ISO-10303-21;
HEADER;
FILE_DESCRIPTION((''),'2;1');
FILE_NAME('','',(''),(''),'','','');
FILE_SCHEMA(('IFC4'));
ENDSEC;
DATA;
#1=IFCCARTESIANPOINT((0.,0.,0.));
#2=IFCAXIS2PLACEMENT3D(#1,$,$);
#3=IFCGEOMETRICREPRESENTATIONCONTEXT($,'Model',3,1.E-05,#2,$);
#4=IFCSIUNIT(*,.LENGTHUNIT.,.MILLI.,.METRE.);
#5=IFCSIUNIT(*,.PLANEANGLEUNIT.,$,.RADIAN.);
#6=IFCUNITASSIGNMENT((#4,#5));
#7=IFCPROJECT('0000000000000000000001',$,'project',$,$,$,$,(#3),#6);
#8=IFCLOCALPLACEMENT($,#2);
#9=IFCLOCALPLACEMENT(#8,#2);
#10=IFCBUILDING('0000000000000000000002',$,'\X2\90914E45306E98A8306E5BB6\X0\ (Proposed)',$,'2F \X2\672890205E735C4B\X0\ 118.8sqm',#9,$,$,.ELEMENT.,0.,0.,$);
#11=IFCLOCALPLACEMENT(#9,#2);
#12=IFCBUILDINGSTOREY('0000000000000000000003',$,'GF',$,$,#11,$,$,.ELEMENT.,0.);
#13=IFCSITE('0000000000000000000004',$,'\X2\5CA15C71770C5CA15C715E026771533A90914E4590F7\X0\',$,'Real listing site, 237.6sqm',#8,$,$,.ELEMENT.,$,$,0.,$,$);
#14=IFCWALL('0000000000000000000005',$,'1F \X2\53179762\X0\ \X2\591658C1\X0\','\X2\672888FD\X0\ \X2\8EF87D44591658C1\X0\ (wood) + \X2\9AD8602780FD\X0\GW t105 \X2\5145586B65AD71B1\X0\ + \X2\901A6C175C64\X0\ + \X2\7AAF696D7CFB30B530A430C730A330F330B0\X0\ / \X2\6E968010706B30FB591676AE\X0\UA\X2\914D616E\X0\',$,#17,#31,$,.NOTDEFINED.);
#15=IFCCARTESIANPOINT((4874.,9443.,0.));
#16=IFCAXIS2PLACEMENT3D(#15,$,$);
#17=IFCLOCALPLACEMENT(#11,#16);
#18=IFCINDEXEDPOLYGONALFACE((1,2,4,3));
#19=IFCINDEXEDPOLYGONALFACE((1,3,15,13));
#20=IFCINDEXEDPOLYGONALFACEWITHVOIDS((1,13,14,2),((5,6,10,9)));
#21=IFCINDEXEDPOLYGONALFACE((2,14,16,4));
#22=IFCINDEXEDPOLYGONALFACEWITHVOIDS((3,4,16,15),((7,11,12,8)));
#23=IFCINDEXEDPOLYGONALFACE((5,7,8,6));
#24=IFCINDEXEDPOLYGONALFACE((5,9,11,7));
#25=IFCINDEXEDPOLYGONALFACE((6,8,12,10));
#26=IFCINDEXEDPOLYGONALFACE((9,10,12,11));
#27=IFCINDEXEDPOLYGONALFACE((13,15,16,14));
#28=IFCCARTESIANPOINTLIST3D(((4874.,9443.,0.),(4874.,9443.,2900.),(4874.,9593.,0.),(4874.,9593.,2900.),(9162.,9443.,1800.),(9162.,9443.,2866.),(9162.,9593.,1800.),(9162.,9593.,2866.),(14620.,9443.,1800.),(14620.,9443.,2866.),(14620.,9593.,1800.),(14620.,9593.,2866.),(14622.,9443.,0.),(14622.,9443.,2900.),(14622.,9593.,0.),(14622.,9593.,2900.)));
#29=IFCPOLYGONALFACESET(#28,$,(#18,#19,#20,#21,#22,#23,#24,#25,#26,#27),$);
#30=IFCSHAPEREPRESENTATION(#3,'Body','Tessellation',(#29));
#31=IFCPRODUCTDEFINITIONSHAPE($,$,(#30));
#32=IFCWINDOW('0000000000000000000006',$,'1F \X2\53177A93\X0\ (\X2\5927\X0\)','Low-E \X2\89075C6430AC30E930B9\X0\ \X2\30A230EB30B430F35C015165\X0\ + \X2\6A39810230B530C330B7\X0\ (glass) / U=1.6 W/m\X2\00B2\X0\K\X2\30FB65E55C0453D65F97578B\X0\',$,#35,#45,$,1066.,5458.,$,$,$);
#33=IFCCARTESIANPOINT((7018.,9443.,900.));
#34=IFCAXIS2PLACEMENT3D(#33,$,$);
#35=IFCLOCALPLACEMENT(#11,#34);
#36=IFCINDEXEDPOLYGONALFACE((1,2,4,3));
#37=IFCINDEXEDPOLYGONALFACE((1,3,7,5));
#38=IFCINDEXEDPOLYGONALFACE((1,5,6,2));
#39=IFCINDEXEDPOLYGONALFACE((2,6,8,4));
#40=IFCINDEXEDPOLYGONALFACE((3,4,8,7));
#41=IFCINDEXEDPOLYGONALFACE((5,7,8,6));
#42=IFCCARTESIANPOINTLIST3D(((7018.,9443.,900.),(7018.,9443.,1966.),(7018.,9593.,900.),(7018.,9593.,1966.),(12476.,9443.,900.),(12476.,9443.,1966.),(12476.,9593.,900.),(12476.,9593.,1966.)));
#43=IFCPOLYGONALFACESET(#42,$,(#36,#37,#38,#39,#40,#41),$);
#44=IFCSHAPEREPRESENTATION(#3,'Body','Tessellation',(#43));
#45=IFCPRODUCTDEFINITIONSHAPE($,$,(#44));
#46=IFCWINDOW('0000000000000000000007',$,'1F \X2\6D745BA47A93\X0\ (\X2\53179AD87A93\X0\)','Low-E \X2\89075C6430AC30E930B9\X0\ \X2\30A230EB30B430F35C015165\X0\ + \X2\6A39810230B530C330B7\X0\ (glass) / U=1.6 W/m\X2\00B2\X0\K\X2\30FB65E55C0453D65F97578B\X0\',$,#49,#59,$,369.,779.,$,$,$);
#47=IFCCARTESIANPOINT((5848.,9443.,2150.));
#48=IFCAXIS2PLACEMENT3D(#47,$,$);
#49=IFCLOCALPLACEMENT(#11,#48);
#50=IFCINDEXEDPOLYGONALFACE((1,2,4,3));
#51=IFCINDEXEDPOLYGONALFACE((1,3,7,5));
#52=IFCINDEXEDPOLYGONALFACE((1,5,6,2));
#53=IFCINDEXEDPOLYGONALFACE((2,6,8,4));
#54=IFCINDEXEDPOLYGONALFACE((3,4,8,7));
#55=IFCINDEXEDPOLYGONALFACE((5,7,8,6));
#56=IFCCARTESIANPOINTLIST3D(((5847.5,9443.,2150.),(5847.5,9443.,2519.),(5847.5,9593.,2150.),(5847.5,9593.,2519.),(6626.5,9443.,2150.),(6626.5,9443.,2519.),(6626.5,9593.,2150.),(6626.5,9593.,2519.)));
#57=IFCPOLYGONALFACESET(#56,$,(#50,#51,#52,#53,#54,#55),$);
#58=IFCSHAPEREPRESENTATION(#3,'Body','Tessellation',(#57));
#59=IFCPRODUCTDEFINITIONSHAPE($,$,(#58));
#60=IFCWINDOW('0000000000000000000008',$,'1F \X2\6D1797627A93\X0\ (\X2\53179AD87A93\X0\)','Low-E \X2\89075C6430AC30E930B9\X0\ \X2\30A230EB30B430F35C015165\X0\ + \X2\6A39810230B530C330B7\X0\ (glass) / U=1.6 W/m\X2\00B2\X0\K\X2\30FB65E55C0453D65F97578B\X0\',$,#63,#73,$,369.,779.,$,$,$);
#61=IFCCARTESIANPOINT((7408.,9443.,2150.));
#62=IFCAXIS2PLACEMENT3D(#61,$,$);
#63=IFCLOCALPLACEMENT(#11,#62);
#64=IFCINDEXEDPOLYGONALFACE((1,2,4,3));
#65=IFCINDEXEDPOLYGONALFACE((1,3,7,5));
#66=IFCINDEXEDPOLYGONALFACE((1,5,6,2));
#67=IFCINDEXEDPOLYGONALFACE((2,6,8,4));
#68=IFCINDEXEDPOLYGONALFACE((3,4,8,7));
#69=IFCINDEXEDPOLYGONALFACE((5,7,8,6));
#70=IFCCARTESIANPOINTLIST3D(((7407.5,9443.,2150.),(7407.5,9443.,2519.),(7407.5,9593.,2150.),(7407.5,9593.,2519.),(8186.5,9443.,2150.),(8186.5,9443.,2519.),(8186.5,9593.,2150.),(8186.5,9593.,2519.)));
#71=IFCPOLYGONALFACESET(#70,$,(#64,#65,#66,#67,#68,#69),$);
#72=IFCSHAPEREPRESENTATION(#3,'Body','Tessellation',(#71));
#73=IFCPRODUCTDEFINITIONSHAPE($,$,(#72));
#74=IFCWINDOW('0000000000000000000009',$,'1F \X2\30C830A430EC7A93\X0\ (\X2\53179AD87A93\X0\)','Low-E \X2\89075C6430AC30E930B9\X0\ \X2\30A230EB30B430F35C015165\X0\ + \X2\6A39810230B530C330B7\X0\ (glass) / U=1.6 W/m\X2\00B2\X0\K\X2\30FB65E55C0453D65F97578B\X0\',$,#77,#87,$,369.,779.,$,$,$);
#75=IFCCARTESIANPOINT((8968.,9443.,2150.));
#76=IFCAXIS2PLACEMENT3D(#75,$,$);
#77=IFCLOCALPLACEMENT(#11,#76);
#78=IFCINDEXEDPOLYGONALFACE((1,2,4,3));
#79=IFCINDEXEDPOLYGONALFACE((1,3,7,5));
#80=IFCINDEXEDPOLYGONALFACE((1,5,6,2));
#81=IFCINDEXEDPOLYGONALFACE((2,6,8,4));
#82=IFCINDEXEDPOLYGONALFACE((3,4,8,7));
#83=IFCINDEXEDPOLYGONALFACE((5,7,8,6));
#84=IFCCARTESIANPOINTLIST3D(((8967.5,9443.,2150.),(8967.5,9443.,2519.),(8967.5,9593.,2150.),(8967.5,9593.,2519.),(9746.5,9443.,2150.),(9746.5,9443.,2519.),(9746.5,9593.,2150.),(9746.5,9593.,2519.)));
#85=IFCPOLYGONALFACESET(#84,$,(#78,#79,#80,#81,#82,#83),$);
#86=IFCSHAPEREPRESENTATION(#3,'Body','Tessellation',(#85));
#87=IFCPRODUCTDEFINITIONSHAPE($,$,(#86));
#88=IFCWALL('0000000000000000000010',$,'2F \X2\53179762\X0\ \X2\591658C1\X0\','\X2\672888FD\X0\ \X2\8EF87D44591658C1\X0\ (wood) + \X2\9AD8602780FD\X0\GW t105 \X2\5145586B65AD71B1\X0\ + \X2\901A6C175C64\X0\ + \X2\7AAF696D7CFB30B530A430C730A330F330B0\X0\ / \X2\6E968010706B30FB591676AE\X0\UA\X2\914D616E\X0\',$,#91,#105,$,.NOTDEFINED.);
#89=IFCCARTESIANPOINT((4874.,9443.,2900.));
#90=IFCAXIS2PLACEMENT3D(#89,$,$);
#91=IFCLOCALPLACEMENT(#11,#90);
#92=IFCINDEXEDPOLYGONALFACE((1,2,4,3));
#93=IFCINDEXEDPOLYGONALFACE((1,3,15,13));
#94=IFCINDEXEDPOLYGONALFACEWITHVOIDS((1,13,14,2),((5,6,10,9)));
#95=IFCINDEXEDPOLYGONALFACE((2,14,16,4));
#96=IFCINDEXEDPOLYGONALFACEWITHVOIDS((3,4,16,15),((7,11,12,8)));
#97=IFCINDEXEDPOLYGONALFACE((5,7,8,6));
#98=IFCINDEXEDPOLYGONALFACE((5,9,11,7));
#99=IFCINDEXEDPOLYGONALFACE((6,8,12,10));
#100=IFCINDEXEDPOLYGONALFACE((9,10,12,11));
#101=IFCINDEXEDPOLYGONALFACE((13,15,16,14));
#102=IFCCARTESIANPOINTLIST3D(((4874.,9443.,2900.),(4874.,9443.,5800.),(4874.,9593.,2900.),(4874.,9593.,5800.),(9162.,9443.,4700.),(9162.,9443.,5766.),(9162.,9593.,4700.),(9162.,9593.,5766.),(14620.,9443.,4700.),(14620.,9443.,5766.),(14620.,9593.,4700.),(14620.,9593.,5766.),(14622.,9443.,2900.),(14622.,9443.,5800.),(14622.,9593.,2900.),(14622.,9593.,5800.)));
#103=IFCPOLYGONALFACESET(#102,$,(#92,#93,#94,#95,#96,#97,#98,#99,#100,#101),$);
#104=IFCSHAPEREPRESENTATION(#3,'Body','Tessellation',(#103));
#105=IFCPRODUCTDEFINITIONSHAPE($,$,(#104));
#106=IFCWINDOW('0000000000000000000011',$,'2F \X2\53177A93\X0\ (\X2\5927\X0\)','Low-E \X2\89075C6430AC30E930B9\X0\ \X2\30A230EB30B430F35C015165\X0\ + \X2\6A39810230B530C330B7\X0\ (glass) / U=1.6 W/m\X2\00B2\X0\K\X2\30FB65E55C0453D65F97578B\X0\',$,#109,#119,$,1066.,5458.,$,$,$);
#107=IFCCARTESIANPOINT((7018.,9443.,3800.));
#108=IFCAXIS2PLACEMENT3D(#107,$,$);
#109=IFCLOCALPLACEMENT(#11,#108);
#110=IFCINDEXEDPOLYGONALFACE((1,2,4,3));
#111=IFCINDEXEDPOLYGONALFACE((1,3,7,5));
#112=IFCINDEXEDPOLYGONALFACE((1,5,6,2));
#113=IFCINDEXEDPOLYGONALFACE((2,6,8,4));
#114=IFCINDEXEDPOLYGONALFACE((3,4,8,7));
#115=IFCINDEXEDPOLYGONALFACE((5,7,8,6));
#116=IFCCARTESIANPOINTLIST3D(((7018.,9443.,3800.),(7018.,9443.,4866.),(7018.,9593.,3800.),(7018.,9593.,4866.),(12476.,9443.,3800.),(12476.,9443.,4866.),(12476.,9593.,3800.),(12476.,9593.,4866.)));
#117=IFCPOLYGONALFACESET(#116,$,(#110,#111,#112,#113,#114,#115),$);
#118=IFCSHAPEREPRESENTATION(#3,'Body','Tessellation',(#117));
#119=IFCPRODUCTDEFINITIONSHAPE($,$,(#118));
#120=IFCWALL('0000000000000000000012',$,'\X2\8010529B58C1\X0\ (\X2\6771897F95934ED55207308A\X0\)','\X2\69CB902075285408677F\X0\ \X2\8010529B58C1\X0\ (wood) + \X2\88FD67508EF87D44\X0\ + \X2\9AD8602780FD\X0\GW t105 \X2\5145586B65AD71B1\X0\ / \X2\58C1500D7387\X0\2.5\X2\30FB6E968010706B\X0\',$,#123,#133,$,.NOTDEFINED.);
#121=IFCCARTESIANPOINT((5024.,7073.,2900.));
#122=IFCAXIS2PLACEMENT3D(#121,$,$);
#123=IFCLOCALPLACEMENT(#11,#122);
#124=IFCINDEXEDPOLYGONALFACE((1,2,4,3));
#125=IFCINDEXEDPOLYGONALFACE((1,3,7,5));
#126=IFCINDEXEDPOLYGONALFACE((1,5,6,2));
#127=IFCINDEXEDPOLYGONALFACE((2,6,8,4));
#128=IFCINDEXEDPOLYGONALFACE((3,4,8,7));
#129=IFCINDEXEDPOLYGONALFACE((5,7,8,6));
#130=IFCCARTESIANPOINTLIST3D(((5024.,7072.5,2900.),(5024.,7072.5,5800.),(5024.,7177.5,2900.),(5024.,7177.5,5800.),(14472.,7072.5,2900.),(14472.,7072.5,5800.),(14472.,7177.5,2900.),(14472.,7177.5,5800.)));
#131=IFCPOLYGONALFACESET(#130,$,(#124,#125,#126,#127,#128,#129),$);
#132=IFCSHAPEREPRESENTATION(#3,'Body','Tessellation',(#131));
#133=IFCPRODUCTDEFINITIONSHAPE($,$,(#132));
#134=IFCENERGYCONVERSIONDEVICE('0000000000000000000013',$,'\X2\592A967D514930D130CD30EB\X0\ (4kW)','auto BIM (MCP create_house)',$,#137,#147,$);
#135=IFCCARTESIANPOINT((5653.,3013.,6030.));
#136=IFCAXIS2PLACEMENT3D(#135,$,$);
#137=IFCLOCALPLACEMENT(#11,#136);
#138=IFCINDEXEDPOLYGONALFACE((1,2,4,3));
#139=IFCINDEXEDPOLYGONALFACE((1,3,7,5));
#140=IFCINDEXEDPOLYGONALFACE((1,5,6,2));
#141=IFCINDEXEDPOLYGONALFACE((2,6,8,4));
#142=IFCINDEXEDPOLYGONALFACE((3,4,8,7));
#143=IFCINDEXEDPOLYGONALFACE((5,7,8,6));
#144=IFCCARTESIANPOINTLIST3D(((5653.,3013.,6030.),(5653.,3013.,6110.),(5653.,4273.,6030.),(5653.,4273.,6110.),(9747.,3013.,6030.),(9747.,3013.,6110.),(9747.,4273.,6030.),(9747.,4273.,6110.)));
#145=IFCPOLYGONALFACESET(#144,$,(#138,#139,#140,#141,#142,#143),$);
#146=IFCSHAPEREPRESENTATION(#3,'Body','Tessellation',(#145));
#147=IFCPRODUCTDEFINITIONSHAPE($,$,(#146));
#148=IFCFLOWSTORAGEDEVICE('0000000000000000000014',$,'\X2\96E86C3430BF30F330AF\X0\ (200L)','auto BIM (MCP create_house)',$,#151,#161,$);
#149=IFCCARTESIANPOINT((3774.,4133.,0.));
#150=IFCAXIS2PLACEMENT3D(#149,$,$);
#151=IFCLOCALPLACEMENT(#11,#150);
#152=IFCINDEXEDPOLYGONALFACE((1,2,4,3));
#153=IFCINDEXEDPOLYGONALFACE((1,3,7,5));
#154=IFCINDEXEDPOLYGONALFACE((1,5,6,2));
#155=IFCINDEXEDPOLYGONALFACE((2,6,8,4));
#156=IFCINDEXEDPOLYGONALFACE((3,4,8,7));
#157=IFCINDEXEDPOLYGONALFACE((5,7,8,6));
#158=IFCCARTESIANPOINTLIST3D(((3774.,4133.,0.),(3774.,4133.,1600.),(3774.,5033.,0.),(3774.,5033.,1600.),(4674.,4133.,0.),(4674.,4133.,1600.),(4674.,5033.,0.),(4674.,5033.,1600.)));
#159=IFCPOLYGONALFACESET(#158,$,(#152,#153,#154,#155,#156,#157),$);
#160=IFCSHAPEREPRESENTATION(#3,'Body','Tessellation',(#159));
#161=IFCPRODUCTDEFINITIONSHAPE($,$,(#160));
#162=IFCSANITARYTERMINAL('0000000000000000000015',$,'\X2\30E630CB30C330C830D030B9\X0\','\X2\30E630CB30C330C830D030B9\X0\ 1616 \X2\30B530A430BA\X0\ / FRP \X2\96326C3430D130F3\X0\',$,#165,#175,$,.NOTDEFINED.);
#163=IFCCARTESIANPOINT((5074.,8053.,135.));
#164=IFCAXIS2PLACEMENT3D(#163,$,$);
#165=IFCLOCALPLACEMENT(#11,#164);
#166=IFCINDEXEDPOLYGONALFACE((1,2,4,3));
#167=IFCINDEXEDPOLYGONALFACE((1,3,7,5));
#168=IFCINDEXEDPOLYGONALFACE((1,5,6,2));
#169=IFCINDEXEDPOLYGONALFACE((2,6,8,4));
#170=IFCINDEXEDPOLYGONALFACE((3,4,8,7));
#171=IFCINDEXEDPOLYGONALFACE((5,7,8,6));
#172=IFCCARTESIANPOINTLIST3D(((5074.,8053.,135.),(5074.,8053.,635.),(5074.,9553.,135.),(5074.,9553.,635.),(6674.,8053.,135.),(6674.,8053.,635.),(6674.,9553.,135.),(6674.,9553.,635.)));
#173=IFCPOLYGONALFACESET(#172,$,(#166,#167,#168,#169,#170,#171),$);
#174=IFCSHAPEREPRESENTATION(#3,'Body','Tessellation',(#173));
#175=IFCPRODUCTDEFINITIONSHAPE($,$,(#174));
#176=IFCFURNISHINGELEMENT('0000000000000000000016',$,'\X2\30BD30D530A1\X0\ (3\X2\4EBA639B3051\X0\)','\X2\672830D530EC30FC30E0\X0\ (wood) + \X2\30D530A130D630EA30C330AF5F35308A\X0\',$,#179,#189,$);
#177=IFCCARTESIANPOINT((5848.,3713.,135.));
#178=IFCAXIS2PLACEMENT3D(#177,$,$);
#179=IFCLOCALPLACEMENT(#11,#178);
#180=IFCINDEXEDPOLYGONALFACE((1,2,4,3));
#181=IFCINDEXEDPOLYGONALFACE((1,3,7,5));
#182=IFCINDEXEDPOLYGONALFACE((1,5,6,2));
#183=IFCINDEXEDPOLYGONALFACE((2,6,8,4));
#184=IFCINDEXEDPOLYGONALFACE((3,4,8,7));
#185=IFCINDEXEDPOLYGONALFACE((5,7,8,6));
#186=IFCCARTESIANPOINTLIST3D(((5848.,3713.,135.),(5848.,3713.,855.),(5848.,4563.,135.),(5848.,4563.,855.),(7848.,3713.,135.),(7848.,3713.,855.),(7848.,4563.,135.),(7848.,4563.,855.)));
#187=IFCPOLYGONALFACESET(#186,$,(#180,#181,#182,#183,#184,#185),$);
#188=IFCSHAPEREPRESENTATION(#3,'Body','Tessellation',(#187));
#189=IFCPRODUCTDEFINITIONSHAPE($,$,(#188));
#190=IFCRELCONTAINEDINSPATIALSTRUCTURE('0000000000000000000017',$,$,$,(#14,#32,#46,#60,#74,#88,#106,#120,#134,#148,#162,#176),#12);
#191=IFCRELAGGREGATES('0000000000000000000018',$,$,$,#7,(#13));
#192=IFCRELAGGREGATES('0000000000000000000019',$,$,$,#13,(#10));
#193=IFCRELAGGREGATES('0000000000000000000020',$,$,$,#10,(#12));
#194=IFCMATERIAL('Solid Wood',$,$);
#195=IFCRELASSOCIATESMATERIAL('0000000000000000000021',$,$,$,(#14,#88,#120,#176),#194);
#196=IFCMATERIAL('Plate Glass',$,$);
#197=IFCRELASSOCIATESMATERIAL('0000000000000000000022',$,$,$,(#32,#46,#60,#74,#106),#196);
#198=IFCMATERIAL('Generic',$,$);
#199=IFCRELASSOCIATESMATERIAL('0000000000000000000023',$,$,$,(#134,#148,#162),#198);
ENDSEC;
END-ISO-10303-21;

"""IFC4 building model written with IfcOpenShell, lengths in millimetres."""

from ifc_helpers import new_model, si_unit, frame, frame_2d, origin, place, context, project, spatial, rectangle, extrude, material, element, fill, save


model = new_model("IFC4")

# Units and contexts
model_context = context("Model", 3, precision=1e-05, world=origin())
ifc_project = project(units=[si_unit("LENGTHUNIT", "METRE", prefix="MILLI"), si_unit("PLANEANGLEUNIT", "RADIAN")], contexts=[model_context])

# Site, building, storey
site_placement = place(None, origin())
site = spatial("IfcSite", under=ifc_project, at=site_placement, Name="岡山県岡山市東区邑久郷", ObjectType="Real listing site, 237.6sqm", CompositionType="ELEMENT", RefElevation=0.0)
building_placement = place(site_placement, origin())
building = spatial("IfcBuilding", under=site, at=building_placement, Name="邑久の風の家 (Proposed)", ObjectType="2F 木造平屋 118.8sqm", CompositionType="ELEMENT", ElevationOfRefHeight=0.0, ElevationOfTerrain=0.0)
storey_placement = place(building_placement, origin())
storey = spatial("IfcBuildingStorey", under=building, at=storey_placement, Name="GF", CompositionType="ELEMENT", Elevation=0.0)

# Wall, openings, windows
ifc_material_1 = material(Name="Solid Wood")
wall_1_placement = place(storey_placement, frame((4874.0, 9443.0, 0.0)))
wall_1 = element("IfcWall", 1, at=wall_1_placement, inside=storey, material=ifc_material_1, Name="1F 北面 外壁", Description="木製 軸組外壁 (wood) + 高性能GW t105 充填断熱 + 通気層 + 窯業系サイディング / 準耐火・外皮UA配慮", PredefinedType="NOTDEFINED", context=model_context, shape_type="SweptSolid", body=[
    extrude(rectangle(XDim=9748.0, YDim=150.0, at=frame_2d((4874.0, 75.0))), frame((4874.0, 9443.0, 0.0)), (0.0, 0.0, 1.0), 2900.0),
])
opening_1_placement = place(storey_placement, frame((7018.0, 9443.0, 900.0)))
opening_1 = element("IfcOpeningElement", 2, at=opening_1_placement, cuts=wall_1, PredefinedType="NOTDEFINED", context=model_context, shape_type="SweptSolid", body=[
    extrude(rectangle(XDim=5458.0, YDim=150.0, at=frame_2d((2729.0, 75.0))), frame((7018.0, 9443.0, 900.0)), (0.0, 0.0, 1.0), 1066.0),
])
opening_2_placement = place(storey_placement, frame((5848.0, 9443.0, 2150.0)))
opening_2 = element("IfcOpeningElement", 3, at=opening_2_placement, cuts=wall_1, PredefinedType="NOTDEFINED", context=model_context, shape_type="SweptSolid", body=[
    extrude(rectangle(XDim=779.0, YDim=150.0, at=frame_2d((389.0, 75.0))), frame((5848.0, 9443.0, 2150.0)), (0.0, 0.0, 1.0), 369.0),
])
opening_3_placement = place(storey_placement, frame((7408.0, 9443.0, 2150.0)))
opening_3 = element("IfcOpeningElement", 4, at=opening_3_placement, cuts=wall_1, PredefinedType="NOTDEFINED", context=model_context, shape_type="SweptSolid", body=[
    extrude(rectangle(XDim=779.0, YDim=150.0, at=frame_2d((389.0, 75.0))), frame((7408.0, 9443.0, 2150.0)), (0.0, 0.0, 1.0), 369.0),
])
opening_4_placement = place(storey_placement, frame((8968.0, 9443.0, 2150.0)))
opening_4 = element("IfcOpeningElement", 5, at=opening_4_placement, cuts=wall_1, PredefinedType="NOTDEFINED", context=model_context, shape_type="SweptSolid", body=[
    extrude(rectangle(XDim=779.0, YDim=150.0, at=frame_2d((389.0, 75.0))), frame((8968.0, 9443.0, 2150.0)), (0.0, 0.0, 1.0), 369.0),
])
ifc_material_2 = material(Name="Plate Glass")
window_1_placement = place(storey_placement, frame((7018.0, 9443.0, 900.0)))
window_1 = element("IfcWindow", 6, at=window_1_placement, inside=storey, material=ifc_material_2, Name="1F 北窓 (大)", Description="Low-E 複層ガラス アルゴン封入 + 樹脂サッシ (glass) / U=1.6 W/m²K・日射取得型", OverallHeight=1066.0, OverallWidth=5458.0, context=model_context, shape_type="SweptSolid", body=[
    extrude(rectangle(XDim=5458.0, YDim=150.0, at=frame_2d((2729.0, 75.0))), frame((7018.0, 9443.0, 900.0)), (0.0, 0.0, 1.0), 1066.0),
])
fill(opening_1, window_1)
window_2_placement = place(storey_placement, frame((5848.0, 9443.0, 2150.0)))
window_2 = element("IfcWindow", 7, at=window_2_placement, inside=storey, material=ifc_material_2, Name="1F 浴室窓 (北高窓)", Description="Low-E 複層ガラス アルゴン封入 + 樹脂サッシ (glass) / U=1.6 W/m²K・日射取得型", OverallHeight=369.0, OverallWidth=779.0, context=model_context, shape_type="SweptSolid", body=[
    extrude(rectangle(XDim=779.0, YDim=150.0, at=frame_2d((389.0, 75.0))), frame((5848.0, 9443.0, 2150.0)), (0.0, 0.0, 1.0), 369.0),
])
fill(opening_2, window_2)
window_3_placement = place(storey_placement, frame((7408.0, 9443.0, 2150.0)))
window_3 = element("IfcWindow", 8, at=window_3_placement, inside=storey, material=ifc_material_2, Name="1F 洗面窓 (北高窓)", Description="Low-E 複層ガラス アルゴン封入 + 樹脂サッシ (glass) / U=1.6 W/m²K・日射取得型", OverallHeight=369.0, OverallWidth=779.0, context=model_context, shape_type="SweptSolid", body=[
    extrude(rectangle(XDim=779.0, YDim=150.0, at=frame_2d((389.0, 75.0))), frame((7408.0, 9443.0, 2150.0)), (0.0, 0.0, 1.0), 369.0),
])
fill(opening_3, window_3)
window_4_placement = place(storey_placement, frame((8968.0, 9443.0, 2150.0)))
window_4 = element("IfcWindow", 9, at=window_4_placement, inside=storey, material=ifc_material_2, Name="1F トイレ窓 (北高窓)", Description="Low-E 複層ガラス アルゴン封入 + 樹脂サッシ (glass) / U=1.6 W/m²K・日射取得型", OverallHeight=369.0, OverallWidth=779.0, context=model_context, shape_type="SweptSolid", body=[
    extrude(rectangle(XDim=779.0, YDim=150.0, at=frame_2d((389.0, 75.0))), frame((8968.0, 9443.0, 2150.0)), (0.0, 0.0, 1.0), 369.0),
])
fill(opening_4, window_4)

# Wall, opening, window
wall_2_placement = place(storey_placement, frame((4874.0, 9443.0, 2900.0)))
wall_2 = element("IfcWall", 10, at=wall_2_placement, inside=storey, material=ifc_material_1, Name="2F 北面 外壁", Description="木製 軸組外壁 (wood) + 高性能GW t105 充填断熱 + 通気層 + 窯業系サイディング / 準耐火・外皮UA配慮", PredefinedType="NOTDEFINED", context=model_context, shape_type="SweptSolid", body=[
    extrude(rectangle(XDim=9748.0, YDim=150.0, at=frame_2d((4874.0, 75.0))), frame((4874.0, 9443.0, 2900.0)), (0.0, 0.0, 1.0), 2900.0),
])
opening_5_placement = place(storey_placement, frame((7018.0, 9443.0, 3800.0)))
opening_5 = element("IfcOpeningElement", 11, at=opening_5_placement, cuts=wall_2, PredefinedType="NOTDEFINED", context=model_context, shape_type="SweptSolid", body=[
    extrude(rectangle(XDim=5458.0, YDim=150.0, at=frame_2d((2729.0, 75.0))), frame((7018.0, 9443.0, 3800.0)), (0.0, 0.0, 1.0), 1066.0),
])
window_5_placement = place(storey_placement, frame((7018.0, 9443.0, 3800.0)))
window_5 = element("IfcWindow", 12, at=window_5_placement, inside=storey, material=ifc_material_2, Name="2F 北窓 (大)", Description="Low-E 複層ガラス アルゴン封入 + 樹脂サッシ (glass) / U=1.6 W/m²K・日射取得型", OverallHeight=1066.0, OverallWidth=5458.0, context=model_context, shape_type="SweptSolid", body=[
    extrude(rectangle(XDim=5458.0, YDim=150.0, at=frame_2d((2729.0, 75.0))), frame((7018.0, 9443.0, 3800.0)), (0.0, 0.0, 1.0), 1066.0),
])
fill(opening_5, window_5)

# Wall
wall_3_placement = place(storey_placement, frame((5024.0, 7073.0, 2900.0)))
element("IfcWall", 13, at=wall_3_placement, inside=storey, material=ifc_material_1, Name="耐力壁 (東西間仕切り)", Description="構造用合板 耐力壁 (wood) + 製材軸組 + 高性能GW t105 充填断熱 / 壁倍率2.5・準耐火", PredefinedType="NOTDEFINED", context=model_context, shape_type="SweptSolid", body=[
    extrude(rectangle(XDim=9448.0, YDim=105.0, at=frame_2d((4724.0, 52.0))), frame((5024.0, 7073.0, 2900.0)), (0.0, 0.0, 1.0), 2900.0),
])

# Energy conversion device
ifc_material_3 = material(Name="Generic")
energy_conversion_device_placement = place(storey_placement, frame((5653.0, 3013.0, 6030.0)))
element("IfcEnergyConversionDevice", 14, at=energy_conversion_device_placement, inside=storey, material=ifc_material_3, Name="太陽光パネル (4kW)", Description="auto BIM (MCP create_house)", context=model_context, shape_type="SweptSolid", body=[
    extrude(rectangle(XDim=4094.0, YDim=1260.0, at=frame_2d((2047.0, 630.0))), frame((5653.0, 3013.0, 6030.0)), (0.0, 0.0, 1.0), 80.0),
])

# Flow storage device
flow_storage_device_placement = place(storey_placement, frame((3774.0, 4133.0, 0.0)))
element("IfcFlowStorageDevice", 15, at=flow_storage_device_placement, inside=storey, material=ifc_material_3, Name="雨水タンク (200L)", Description="auto BIM (MCP create_house)", context=model_context, shape_type="SweptSolid", body=[
    extrude(rectangle(XDim=900.0, YDim=900.0, at=frame_2d((450.0, 450.0))), frame((3774.0, 4133.0, 0.0)), (0.0, 0.0, 1.0), 1600.0),
])

# Sanitary terminal
sanitary_terminal_placement = place(storey_placement, frame((5074.0, 8053.0, 135.0)))
element("IfcSanitaryTerminal", 16, at=sanitary_terminal_placement, inside=storey, material=ifc_material_3, Name="ユニットバス", Description="ユニットバス 1616 サイズ / FRP 防水パン", PredefinedType="NOTDEFINED", context=model_context, shape_type="SweptSolid", body=[
    extrude(rectangle(XDim=1600.0, YDim=1500.0, at=frame_2d((800.0, 750.0))), frame((5074.0, 8053.0, 135.0)), (0.0, 0.0, 1.0), 500.0),
])

# Furnishing element
furnishing_1_placement = place(storey_placement, frame((5848.0, 3713.0, 135.0)))
element("IfcFurnishingElement", 17, at=furnishing_1_placement, inside=storey, material=ifc_material_1, Name="ソファ (3人掛け)", Description="木フレーム (wood) + ファブリック張り", context=model_context, shape_type="SweptSolid", body=[
    extrude(rectangle(XDim=2000.0, YDim=850.0, at=frame_2d((1000.0, 425.0))), frame((5848.0, 3713.0, 135.0)), (0.0, 0.0, 1.0), 720.0),
])

save(model, "model.ifc")
